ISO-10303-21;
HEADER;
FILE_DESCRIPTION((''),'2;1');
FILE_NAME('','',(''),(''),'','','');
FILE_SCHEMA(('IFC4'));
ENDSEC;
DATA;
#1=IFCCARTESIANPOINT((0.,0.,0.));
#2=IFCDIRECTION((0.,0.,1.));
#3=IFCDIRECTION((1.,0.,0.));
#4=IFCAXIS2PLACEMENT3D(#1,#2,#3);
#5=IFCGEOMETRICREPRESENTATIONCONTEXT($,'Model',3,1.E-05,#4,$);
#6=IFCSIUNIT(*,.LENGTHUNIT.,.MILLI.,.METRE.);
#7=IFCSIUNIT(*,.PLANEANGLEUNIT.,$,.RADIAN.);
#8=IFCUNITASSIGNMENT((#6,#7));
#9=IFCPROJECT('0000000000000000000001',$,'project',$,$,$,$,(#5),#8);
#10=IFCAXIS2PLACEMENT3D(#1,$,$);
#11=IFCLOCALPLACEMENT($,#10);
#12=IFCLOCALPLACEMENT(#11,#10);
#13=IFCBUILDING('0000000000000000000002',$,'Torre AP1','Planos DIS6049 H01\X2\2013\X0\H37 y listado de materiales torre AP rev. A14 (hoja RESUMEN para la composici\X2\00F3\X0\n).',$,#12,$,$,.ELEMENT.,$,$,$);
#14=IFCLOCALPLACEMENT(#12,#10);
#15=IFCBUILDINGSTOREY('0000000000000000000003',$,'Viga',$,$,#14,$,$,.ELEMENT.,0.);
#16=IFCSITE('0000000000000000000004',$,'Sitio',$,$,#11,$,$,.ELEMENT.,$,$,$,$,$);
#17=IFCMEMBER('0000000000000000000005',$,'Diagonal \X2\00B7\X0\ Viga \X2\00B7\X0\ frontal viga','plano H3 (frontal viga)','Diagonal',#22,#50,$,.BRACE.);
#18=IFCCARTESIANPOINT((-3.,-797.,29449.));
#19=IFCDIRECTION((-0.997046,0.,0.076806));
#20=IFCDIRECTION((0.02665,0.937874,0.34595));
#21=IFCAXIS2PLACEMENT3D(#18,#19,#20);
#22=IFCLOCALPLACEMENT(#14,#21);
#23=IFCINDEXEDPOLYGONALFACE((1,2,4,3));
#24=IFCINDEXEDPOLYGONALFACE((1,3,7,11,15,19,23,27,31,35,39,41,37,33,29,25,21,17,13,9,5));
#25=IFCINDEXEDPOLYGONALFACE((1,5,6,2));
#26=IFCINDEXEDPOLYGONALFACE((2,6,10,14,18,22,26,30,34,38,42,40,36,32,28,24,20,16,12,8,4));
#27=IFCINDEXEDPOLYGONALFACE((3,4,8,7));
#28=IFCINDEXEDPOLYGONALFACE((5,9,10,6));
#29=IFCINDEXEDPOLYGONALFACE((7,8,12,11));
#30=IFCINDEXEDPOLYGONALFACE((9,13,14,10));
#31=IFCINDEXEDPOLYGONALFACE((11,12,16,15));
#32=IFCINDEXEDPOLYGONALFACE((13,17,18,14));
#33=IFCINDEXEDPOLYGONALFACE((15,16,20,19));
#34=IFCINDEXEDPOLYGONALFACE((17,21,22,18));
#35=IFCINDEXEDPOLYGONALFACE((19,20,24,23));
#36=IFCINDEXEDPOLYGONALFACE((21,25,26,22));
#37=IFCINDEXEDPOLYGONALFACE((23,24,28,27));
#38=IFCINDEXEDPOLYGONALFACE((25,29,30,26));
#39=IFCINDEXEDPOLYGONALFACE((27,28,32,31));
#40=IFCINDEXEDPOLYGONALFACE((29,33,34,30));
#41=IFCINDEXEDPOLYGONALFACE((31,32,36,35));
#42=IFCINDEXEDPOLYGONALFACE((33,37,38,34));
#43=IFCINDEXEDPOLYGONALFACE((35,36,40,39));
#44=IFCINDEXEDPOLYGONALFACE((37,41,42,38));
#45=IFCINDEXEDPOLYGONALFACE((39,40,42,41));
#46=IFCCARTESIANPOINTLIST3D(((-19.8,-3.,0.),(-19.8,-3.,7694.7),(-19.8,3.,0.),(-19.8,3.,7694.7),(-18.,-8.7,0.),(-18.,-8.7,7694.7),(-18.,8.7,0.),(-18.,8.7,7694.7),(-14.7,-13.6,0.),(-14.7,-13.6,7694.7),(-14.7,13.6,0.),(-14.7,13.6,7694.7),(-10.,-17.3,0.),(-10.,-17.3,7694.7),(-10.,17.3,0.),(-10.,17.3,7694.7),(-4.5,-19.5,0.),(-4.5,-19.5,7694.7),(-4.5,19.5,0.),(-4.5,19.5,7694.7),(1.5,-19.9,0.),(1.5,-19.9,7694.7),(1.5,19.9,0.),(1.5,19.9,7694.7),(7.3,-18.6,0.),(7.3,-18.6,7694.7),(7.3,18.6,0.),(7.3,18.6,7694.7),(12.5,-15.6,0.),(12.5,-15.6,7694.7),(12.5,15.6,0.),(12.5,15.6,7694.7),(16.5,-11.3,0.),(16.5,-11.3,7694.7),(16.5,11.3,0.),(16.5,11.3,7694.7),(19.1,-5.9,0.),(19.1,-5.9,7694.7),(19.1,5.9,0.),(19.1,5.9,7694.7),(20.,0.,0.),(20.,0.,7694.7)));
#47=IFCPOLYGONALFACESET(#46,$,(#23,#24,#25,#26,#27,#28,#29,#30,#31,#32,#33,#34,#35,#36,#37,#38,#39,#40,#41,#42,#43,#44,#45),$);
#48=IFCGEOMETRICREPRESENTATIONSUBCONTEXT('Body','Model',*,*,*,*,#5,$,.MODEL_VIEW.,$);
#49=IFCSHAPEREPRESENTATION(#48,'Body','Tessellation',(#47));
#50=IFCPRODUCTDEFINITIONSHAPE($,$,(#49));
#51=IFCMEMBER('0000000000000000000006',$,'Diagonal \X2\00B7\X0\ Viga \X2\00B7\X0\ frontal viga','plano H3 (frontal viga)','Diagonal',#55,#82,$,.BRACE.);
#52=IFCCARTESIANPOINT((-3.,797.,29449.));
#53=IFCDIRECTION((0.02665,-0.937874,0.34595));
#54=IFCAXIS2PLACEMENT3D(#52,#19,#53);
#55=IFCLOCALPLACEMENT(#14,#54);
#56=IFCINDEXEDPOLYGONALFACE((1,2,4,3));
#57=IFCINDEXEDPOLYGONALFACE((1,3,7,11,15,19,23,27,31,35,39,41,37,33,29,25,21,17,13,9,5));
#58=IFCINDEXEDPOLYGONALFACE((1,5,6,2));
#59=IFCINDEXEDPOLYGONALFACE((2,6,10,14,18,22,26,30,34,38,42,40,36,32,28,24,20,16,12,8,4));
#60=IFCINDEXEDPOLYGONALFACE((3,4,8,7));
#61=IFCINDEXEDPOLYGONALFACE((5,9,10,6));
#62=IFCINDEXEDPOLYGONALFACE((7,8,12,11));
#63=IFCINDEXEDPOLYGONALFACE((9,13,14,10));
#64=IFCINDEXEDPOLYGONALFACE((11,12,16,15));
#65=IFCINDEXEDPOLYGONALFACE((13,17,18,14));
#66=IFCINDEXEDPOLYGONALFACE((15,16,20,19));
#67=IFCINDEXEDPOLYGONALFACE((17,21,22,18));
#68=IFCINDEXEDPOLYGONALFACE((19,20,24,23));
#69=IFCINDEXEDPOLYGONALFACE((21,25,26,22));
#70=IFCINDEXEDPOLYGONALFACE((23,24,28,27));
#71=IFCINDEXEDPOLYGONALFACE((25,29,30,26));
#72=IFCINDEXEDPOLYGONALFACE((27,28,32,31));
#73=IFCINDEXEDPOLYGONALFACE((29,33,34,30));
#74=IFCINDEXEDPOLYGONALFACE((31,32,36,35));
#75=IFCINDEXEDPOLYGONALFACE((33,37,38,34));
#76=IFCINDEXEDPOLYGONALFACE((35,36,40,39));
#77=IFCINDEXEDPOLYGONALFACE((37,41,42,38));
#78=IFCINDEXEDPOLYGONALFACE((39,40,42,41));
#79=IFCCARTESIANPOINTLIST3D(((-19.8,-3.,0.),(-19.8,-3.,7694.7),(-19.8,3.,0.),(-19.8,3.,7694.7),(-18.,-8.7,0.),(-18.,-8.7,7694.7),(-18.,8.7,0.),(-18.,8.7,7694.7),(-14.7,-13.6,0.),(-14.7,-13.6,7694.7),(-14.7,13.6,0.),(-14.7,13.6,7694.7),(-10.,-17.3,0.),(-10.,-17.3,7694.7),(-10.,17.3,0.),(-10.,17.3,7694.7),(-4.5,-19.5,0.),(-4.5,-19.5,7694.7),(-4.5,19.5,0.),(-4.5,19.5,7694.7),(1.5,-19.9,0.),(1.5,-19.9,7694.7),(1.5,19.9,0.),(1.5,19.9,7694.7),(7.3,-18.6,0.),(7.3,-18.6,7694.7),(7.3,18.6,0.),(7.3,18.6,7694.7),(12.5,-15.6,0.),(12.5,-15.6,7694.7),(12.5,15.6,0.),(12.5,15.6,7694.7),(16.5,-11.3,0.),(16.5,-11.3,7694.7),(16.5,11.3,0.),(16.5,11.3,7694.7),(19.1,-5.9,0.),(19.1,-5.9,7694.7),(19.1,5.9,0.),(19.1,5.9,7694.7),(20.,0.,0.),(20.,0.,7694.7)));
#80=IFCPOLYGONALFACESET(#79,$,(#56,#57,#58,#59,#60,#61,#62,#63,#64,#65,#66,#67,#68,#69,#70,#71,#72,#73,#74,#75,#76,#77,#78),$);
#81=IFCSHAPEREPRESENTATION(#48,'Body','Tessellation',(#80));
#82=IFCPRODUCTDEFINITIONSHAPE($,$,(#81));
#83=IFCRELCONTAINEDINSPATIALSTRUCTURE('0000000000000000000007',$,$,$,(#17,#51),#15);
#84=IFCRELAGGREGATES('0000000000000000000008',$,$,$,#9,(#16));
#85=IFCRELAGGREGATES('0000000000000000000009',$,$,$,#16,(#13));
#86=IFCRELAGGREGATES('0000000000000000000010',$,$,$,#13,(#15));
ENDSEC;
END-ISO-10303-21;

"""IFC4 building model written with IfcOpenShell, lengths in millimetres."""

from ifc_helpers import new_model, si_unit, frame, origin, origin_with_axes, place, context, subcontext, project, spatial, circle, extrude, element, save


model = new_model("IFC4")

# Units and contexts
model_context = context("Model", 3, precision=1e-05, world=origin_with_axes())
body_context = subcontext(model_context, "Body", "Model", "MODEL_VIEW")
ifc_project = project(units=[si_unit("LENGTHUNIT", "METRE", prefix="MILLI"), si_unit("PLANEANGLEUNIT", "RADIAN")], contexts=[model_context])

# Site, building, storey
site_placement = place(None, origin())
site = spatial("IfcSite", under=ifc_project, at=site_placement, Name="Sitio", CompositionType="ELEMENT")
building_placement = place(site_placement, origin())
building = spatial("IfcBuilding", under=site, at=building_placement, Name="Torre AP1", Description="Planos DIS6049 H01–H37 y listado de materiales torre AP rev. A14 (hoja RESUMEN para la composición).", CompositionType="ELEMENT")
storey_placement = place(building_placement, origin())
storey = spatial("IfcBuildingStorey", under=building, at=storey_placement, Name="Viga", CompositionType="ELEMENT", Elevation=0.0)

# Members
for number, where, z_axis, x_axis, name in (
    (1, (-3.0, -797.0, 29449.0), (-0.997046, 0.0, 0.076806), (0.02665, 0.937874, 0.34595), "Diagonal · Viga · frontal viga"),
    (2, (-3.0, 797.0, 29449.0), (-0.997046, 0.0, 0.076806), (0.02665, -0.937874, 0.34595), "Diagonal · Viga · frontal viga"),
):
    element("IfcMember", number, at=place(storey_placement, frame(where, z_axis=z_axis, x_axis=x_axis)), inside=storey, Name=name, Description="plano H3 (frontal viga)", ObjectType="Diagonal", PredefinedType="BRACE", context=body_context, shape_type="SweptSolid", body=[
        extrude(circle(Radius=20.0), None, (0.0, 0.0, 1.0), 7694.7),
    ])

save(model, "model.ifc")
